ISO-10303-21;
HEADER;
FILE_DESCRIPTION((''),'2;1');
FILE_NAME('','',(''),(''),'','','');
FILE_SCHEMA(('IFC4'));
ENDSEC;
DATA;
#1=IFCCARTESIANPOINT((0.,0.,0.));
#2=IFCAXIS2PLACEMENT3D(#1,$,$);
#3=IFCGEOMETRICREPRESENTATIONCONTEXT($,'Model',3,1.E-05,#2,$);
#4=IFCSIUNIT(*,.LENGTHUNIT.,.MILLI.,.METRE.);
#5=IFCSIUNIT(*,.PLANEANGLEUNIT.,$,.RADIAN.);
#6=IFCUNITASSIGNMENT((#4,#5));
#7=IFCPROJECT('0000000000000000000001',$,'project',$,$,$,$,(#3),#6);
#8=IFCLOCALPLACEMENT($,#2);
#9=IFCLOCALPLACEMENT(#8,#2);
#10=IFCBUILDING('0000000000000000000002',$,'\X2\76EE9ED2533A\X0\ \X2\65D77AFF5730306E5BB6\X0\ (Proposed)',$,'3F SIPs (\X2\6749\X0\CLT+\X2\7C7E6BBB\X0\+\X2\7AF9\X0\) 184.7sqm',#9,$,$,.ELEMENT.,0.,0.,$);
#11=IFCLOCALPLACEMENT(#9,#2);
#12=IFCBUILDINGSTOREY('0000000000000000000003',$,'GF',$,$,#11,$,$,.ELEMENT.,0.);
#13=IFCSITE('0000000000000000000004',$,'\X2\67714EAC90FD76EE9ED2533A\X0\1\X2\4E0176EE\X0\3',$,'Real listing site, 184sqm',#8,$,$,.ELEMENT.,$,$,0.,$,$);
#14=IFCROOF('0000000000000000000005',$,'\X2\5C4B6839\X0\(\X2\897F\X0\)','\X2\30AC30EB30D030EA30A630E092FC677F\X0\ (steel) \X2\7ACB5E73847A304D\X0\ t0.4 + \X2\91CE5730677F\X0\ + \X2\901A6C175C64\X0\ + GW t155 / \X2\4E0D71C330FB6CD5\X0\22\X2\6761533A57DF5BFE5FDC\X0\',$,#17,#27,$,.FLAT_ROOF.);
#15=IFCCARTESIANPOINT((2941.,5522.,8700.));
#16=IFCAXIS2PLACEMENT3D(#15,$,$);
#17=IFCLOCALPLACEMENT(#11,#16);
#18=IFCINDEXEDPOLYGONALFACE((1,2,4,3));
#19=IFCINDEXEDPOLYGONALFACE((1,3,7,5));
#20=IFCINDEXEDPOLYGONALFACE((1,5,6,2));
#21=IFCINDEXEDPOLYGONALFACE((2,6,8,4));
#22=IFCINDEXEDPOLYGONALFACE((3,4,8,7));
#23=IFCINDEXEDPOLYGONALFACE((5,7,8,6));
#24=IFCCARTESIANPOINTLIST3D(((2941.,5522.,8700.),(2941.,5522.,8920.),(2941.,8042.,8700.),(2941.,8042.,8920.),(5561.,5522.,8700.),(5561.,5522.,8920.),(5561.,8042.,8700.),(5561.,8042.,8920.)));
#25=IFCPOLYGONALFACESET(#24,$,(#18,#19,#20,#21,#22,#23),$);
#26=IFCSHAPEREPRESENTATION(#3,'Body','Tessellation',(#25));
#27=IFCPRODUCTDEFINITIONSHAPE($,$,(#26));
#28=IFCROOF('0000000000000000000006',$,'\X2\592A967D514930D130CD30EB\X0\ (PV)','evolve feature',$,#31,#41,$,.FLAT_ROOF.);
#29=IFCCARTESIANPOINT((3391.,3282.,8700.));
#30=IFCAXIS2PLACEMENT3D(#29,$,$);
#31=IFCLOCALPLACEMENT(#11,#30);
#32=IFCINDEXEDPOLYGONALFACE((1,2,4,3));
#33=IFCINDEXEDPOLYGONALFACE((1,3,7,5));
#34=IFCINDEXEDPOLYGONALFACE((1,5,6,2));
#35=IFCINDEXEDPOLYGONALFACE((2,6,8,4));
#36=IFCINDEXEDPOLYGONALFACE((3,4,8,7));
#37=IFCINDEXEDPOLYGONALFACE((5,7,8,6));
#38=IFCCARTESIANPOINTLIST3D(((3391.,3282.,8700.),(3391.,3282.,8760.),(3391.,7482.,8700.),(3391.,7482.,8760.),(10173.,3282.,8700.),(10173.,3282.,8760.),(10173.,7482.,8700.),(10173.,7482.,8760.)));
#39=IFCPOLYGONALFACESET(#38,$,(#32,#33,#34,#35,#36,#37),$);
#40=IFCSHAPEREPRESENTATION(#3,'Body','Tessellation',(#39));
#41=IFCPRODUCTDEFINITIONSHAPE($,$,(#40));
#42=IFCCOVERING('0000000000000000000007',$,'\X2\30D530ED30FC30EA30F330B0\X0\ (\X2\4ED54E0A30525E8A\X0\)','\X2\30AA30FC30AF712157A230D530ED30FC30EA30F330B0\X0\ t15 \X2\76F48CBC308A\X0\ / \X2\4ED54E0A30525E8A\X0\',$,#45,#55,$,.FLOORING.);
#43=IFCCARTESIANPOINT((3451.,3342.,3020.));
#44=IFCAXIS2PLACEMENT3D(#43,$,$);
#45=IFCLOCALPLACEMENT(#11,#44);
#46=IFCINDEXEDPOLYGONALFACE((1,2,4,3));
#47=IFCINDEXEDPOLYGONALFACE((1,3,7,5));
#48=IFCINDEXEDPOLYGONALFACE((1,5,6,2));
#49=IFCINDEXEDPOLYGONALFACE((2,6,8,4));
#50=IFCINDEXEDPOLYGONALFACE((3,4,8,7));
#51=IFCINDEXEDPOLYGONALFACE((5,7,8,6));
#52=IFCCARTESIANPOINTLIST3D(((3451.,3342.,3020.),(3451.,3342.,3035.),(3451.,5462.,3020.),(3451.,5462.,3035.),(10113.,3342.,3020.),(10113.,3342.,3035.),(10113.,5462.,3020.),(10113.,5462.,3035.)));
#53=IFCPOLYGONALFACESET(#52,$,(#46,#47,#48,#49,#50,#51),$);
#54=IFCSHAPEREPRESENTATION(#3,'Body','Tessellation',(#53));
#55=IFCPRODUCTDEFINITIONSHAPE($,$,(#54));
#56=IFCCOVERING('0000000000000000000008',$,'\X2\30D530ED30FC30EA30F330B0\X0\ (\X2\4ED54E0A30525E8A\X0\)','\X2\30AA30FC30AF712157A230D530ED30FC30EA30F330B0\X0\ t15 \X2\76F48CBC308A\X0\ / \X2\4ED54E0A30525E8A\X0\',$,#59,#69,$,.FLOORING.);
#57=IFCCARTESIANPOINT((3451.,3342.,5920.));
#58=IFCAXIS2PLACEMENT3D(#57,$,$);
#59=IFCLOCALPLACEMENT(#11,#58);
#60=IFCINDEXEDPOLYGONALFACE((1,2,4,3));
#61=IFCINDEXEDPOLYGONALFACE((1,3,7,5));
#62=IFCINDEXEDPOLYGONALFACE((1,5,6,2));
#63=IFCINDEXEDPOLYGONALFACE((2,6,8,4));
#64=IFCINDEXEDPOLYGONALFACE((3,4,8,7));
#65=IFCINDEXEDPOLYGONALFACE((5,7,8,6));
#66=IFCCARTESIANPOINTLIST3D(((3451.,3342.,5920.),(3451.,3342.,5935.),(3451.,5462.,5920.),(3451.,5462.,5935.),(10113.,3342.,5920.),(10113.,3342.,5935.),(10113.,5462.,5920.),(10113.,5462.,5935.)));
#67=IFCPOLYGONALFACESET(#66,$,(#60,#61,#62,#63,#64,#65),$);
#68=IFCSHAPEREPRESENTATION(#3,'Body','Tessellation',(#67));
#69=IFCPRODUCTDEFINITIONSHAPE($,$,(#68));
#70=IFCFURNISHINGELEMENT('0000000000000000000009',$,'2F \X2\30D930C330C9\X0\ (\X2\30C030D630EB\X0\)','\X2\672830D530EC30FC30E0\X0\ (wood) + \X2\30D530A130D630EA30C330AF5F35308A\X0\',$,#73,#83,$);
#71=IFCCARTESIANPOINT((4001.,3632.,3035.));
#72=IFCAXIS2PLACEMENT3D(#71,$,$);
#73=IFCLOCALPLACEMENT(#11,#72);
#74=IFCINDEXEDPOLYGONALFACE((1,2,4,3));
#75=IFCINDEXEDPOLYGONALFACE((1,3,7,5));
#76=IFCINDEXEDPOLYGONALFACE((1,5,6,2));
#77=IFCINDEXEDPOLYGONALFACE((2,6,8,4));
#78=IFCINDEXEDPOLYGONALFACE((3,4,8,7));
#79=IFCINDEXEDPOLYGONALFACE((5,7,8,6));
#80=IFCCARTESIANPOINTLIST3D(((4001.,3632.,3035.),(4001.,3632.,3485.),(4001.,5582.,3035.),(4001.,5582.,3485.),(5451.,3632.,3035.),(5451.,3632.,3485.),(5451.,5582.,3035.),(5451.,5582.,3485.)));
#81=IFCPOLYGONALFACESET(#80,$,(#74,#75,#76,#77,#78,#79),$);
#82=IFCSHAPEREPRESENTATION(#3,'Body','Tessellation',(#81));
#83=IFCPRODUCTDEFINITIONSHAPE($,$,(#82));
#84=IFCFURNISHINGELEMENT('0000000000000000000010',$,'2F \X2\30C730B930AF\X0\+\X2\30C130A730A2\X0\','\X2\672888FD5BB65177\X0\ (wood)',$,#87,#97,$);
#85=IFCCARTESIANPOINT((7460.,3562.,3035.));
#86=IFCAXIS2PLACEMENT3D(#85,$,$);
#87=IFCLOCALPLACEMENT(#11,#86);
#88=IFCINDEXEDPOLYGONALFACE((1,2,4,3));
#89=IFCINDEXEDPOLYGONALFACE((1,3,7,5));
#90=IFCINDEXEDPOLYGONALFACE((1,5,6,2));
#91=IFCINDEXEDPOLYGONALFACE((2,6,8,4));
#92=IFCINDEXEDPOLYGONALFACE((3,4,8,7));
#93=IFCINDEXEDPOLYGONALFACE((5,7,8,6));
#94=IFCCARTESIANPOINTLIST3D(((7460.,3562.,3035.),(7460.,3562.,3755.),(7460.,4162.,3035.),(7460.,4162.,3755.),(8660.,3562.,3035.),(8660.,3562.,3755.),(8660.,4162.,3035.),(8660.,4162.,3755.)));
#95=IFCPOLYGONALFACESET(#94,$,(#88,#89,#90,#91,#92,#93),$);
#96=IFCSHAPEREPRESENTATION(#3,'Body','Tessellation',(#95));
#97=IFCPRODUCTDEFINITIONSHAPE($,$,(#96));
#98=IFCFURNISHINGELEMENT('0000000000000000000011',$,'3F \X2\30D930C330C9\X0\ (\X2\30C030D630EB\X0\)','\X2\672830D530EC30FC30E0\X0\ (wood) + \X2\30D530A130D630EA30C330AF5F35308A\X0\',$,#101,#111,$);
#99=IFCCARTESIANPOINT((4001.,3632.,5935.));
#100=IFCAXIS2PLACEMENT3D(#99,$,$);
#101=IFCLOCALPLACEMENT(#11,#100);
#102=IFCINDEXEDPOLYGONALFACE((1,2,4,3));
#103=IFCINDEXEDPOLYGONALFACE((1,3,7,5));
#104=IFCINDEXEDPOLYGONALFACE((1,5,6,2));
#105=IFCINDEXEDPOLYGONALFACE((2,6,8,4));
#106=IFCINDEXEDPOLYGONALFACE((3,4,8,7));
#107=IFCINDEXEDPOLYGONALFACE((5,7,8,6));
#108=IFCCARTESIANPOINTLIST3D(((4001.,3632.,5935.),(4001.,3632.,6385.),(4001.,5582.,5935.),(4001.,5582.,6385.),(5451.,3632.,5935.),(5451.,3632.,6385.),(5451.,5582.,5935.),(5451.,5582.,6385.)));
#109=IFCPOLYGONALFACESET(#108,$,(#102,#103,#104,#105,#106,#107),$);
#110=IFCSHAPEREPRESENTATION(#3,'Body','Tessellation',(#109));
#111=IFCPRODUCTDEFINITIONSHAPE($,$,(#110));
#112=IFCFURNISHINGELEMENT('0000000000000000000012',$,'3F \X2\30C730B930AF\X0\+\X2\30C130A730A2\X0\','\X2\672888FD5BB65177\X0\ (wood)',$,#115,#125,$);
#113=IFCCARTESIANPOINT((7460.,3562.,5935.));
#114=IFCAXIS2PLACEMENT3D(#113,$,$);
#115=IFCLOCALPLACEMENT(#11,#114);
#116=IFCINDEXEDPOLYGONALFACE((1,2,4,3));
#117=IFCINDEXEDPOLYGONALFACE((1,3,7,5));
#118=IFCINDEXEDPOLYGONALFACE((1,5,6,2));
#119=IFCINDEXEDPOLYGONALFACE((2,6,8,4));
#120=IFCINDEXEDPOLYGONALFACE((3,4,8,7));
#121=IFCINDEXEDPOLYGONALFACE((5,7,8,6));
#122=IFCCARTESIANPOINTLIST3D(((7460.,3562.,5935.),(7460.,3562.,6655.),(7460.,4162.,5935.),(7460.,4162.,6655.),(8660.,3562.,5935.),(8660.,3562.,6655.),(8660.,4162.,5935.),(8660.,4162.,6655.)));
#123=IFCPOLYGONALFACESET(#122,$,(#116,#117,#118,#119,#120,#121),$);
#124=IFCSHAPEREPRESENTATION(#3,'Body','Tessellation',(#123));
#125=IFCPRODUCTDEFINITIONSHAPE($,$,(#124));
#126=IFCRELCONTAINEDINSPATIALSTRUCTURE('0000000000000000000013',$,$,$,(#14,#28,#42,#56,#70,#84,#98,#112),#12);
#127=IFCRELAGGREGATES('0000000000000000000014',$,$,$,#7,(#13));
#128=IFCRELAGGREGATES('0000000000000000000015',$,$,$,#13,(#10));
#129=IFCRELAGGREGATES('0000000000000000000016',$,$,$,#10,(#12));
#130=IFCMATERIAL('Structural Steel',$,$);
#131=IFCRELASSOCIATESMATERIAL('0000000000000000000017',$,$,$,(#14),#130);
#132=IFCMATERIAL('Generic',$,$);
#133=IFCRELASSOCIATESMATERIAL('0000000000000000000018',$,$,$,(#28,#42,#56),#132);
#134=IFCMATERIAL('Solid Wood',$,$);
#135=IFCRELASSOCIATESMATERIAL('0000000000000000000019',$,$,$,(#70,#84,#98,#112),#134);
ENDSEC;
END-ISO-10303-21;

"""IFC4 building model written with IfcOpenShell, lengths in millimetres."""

from ifc_helpers import new_model, si_unit, frame, frame_2d, origin, place, context, project, spatial, rectangle, extrude, material, element, save


model = new_model("IFC4")

# Units and contexts
model_context = context("Model", 3, precision=1e-05, world=origin())
ifc_project = project(units=[si_unit("LENGTHUNIT", "METRE", prefix="MILLI"), si_unit("PLANEANGLEUNIT", "RADIAN")], contexts=[model_context])

# Site, building, storey
site_placement = place(None, origin())
site = spatial("IfcSite", under=ifc_project, at=site_placement, Name="東京都目黒区1丁目3", ObjectType="Real listing site, 184sqm", CompositionType="ELEMENT", RefElevation=0.0)
building_placement = place(site_placement, origin())
building = spatial("IfcBuilding", under=site, at=building_placement, Name="目黒区 旗竿地の家 (Proposed)", ObjectType="3F SIPs (杉CLT+籾殻+竹) 184.7sqm", CompositionType="ELEMENT", ElevationOfRefHeight=0.0, ElevationOfTerrain=0.0)
storey_placement = place(building_placement, origin())
storey = spatial("IfcBuildingStorey", under=building, at=storey_placement, Name="GF", CompositionType="ELEMENT", Elevation=0.0)

# Shared definitions
ifc_material_1 = material(Name="Solid Wood")

# Roofs
ifc_material_2 = material(Name="Structural Steel")
roof_1_placement = place(storey_placement, frame((2941.0, 5522.0, 8700.0)))
element("IfcRoof", 1, at=roof_1_placement, inside=storey, material=ifc_material_2, Name="屋根(西)", Description="ガルバリウム鋼板 (steel) 立平葺き t0.4 + 野地板 + 通気層 + GW t155 / 不燃・法22条区域対応", PredefinedType="FLAT_ROOF", context=model_context, shape_type="SweptSolid", body=[
    extrude(rectangle(XDim=2620.0, YDim=2520.0, at=frame_2d((1310.0, 1260.0))), frame((2941.0, 5522.0, 8700.0)), (0.0, 0.0, 1.0), 220.0),
])
ifc_material_3 = material(Name="Generic")
roof_2_placement = place(storey_placement, frame((3391.0, 3282.0, 8700.0)))
element("IfcRoof", 2, at=roof_2_placement, inside=storey, material=ifc_material_3, Name="太陽光パネル (PV)", Description="evolve feature", PredefinedType="FLAT_ROOF", context=model_context, shape_type="SweptSolid", body=[
    extrude(rectangle(XDim=6782.0, YDim=4200.0, at=frame_2d((3391.0, 2100.0))), frame((3391.0, 3282.0, 8700.0)), (0.0, 0.0, 1.0), 60.0),
])

# Coverings
covering_1_placement = place(storey_placement, frame((3451.0, 3342.0, 3020.0)))
element("IfcCovering", 3, at=covering_1_placement, inside=storey, material=ifc_material_3, Name="フローリング (仕上げ床)", Description="オーク無垢フローリング t15 直貼り / 仕上げ床", PredefinedType="FLOORING", context=model_context, shape_type="SweptSolid", body=[
    extrude(rectangle(XDim=6662.0, YDim=2120.0, at=frame_2d((3331.0, 1060.0))), frame((3451.0, 3342.0, 3020.0)), (0.0, 0.0, 1.0), 15.0),
])
covering_2_placement = place(storey_placement, frame((3451.0, 3342.0, 5920.0)))
element("IfcCovering", 4, at=covering_2_placement, inside=storey, material=ifc_material_3, Name="フローリング (仕上げ床)", Description="オーク無垢フローリング t15 直貼り / 仕上げ床", PredefinedType="FLOORING", context=model_context, shape_type="SweptSolid", body=[
    extrude(rectangle(XDim=6662.0, YDim=2120.0, at=frame_2d((3331.0, 1060.0))), frame((3451.0, 3342.0, 5920.0)), (0.0, 0.0, 1.0), 15.0),
])

# Furnishing elements
furnishing_1_placement = place(storey_placement, frame((4001.0, 3632.0, 3035.0)))
element("IfcFurnishingElement", 5, at=furnishing_1_placement, inside=storey, material=ifc_material_1, Name="2F ベッド (ダブル)", Description="木フレーム (wood) + ファブリック張り", context=model_context, shape_type="SweptSolid", body=[
    extrude(rectangle(XDim=1450.0, YDim=1950.0, at=frame_2d((725.0, 975.0))), frame((4001.0, 3632.0, 3035.0)), (0.0, 0.0, 1.0), 450.0),
])
furnishing_2_placement = place(storey_placement, frame((7460.0, 3562.0, 3035.0)))
element("IfcFurnishingElement", 6, at=furnishing_2_placement, inside=storey, material=ifc_material_1, Name="2F デスク+チェア", Description="木製家具 (wood)", context=model_context, shape_type="SweptSolid", body=[
    extrude(rectangle(XDim=1200.0, YDim=600.0, at=frame_2d((600.0, 300.0))), frame((7460.0, 3562.0, 3035.0)), (0.0, 0.0, 1.0), 720.0),
])
furnishing_3_placement = place(storey_placement, frame((4001.0, 3632.0, 5935.0)))
element("IfcFurnishingElement", 7, at=furnishing_3_placement, inside=storey, material=ifc_material_1, Name="3F ベッド (ダブル)", Description="木フレーム (wood) + ファブリック張り", context=model_context, shape_type="SweptSolid", body=[
    extrude(rectangle(XDim=1450.0, YDim=1950.0, at=frame_2d((725.0, 975.0))), frame((4001.0, 3632.0, 5935.0)), (0.0, 0.0, 1.0), 450.0),
])
furnishing_4_placement = place(storey_placement, frame((7460.0, 3562.0, 5935.0)))
element("IfcFurnishingElement", 8, at=furnishing_4_placement, inside=storey, material=ifc_material_1, Name="3F デスク+チェア", Description="木製家具 (wood)", context=model_context, shape_type="SweptSolid", body=[
    extrude(rectangle(XDim=1200.0, YDim=600.0, at=frame_2d((600.0, 300.0))), frame((7460.0, 3562.0, 5935.0)), (0.0, 0.0, 1.0), 720.0),
])

save(model, "model.ifc")
